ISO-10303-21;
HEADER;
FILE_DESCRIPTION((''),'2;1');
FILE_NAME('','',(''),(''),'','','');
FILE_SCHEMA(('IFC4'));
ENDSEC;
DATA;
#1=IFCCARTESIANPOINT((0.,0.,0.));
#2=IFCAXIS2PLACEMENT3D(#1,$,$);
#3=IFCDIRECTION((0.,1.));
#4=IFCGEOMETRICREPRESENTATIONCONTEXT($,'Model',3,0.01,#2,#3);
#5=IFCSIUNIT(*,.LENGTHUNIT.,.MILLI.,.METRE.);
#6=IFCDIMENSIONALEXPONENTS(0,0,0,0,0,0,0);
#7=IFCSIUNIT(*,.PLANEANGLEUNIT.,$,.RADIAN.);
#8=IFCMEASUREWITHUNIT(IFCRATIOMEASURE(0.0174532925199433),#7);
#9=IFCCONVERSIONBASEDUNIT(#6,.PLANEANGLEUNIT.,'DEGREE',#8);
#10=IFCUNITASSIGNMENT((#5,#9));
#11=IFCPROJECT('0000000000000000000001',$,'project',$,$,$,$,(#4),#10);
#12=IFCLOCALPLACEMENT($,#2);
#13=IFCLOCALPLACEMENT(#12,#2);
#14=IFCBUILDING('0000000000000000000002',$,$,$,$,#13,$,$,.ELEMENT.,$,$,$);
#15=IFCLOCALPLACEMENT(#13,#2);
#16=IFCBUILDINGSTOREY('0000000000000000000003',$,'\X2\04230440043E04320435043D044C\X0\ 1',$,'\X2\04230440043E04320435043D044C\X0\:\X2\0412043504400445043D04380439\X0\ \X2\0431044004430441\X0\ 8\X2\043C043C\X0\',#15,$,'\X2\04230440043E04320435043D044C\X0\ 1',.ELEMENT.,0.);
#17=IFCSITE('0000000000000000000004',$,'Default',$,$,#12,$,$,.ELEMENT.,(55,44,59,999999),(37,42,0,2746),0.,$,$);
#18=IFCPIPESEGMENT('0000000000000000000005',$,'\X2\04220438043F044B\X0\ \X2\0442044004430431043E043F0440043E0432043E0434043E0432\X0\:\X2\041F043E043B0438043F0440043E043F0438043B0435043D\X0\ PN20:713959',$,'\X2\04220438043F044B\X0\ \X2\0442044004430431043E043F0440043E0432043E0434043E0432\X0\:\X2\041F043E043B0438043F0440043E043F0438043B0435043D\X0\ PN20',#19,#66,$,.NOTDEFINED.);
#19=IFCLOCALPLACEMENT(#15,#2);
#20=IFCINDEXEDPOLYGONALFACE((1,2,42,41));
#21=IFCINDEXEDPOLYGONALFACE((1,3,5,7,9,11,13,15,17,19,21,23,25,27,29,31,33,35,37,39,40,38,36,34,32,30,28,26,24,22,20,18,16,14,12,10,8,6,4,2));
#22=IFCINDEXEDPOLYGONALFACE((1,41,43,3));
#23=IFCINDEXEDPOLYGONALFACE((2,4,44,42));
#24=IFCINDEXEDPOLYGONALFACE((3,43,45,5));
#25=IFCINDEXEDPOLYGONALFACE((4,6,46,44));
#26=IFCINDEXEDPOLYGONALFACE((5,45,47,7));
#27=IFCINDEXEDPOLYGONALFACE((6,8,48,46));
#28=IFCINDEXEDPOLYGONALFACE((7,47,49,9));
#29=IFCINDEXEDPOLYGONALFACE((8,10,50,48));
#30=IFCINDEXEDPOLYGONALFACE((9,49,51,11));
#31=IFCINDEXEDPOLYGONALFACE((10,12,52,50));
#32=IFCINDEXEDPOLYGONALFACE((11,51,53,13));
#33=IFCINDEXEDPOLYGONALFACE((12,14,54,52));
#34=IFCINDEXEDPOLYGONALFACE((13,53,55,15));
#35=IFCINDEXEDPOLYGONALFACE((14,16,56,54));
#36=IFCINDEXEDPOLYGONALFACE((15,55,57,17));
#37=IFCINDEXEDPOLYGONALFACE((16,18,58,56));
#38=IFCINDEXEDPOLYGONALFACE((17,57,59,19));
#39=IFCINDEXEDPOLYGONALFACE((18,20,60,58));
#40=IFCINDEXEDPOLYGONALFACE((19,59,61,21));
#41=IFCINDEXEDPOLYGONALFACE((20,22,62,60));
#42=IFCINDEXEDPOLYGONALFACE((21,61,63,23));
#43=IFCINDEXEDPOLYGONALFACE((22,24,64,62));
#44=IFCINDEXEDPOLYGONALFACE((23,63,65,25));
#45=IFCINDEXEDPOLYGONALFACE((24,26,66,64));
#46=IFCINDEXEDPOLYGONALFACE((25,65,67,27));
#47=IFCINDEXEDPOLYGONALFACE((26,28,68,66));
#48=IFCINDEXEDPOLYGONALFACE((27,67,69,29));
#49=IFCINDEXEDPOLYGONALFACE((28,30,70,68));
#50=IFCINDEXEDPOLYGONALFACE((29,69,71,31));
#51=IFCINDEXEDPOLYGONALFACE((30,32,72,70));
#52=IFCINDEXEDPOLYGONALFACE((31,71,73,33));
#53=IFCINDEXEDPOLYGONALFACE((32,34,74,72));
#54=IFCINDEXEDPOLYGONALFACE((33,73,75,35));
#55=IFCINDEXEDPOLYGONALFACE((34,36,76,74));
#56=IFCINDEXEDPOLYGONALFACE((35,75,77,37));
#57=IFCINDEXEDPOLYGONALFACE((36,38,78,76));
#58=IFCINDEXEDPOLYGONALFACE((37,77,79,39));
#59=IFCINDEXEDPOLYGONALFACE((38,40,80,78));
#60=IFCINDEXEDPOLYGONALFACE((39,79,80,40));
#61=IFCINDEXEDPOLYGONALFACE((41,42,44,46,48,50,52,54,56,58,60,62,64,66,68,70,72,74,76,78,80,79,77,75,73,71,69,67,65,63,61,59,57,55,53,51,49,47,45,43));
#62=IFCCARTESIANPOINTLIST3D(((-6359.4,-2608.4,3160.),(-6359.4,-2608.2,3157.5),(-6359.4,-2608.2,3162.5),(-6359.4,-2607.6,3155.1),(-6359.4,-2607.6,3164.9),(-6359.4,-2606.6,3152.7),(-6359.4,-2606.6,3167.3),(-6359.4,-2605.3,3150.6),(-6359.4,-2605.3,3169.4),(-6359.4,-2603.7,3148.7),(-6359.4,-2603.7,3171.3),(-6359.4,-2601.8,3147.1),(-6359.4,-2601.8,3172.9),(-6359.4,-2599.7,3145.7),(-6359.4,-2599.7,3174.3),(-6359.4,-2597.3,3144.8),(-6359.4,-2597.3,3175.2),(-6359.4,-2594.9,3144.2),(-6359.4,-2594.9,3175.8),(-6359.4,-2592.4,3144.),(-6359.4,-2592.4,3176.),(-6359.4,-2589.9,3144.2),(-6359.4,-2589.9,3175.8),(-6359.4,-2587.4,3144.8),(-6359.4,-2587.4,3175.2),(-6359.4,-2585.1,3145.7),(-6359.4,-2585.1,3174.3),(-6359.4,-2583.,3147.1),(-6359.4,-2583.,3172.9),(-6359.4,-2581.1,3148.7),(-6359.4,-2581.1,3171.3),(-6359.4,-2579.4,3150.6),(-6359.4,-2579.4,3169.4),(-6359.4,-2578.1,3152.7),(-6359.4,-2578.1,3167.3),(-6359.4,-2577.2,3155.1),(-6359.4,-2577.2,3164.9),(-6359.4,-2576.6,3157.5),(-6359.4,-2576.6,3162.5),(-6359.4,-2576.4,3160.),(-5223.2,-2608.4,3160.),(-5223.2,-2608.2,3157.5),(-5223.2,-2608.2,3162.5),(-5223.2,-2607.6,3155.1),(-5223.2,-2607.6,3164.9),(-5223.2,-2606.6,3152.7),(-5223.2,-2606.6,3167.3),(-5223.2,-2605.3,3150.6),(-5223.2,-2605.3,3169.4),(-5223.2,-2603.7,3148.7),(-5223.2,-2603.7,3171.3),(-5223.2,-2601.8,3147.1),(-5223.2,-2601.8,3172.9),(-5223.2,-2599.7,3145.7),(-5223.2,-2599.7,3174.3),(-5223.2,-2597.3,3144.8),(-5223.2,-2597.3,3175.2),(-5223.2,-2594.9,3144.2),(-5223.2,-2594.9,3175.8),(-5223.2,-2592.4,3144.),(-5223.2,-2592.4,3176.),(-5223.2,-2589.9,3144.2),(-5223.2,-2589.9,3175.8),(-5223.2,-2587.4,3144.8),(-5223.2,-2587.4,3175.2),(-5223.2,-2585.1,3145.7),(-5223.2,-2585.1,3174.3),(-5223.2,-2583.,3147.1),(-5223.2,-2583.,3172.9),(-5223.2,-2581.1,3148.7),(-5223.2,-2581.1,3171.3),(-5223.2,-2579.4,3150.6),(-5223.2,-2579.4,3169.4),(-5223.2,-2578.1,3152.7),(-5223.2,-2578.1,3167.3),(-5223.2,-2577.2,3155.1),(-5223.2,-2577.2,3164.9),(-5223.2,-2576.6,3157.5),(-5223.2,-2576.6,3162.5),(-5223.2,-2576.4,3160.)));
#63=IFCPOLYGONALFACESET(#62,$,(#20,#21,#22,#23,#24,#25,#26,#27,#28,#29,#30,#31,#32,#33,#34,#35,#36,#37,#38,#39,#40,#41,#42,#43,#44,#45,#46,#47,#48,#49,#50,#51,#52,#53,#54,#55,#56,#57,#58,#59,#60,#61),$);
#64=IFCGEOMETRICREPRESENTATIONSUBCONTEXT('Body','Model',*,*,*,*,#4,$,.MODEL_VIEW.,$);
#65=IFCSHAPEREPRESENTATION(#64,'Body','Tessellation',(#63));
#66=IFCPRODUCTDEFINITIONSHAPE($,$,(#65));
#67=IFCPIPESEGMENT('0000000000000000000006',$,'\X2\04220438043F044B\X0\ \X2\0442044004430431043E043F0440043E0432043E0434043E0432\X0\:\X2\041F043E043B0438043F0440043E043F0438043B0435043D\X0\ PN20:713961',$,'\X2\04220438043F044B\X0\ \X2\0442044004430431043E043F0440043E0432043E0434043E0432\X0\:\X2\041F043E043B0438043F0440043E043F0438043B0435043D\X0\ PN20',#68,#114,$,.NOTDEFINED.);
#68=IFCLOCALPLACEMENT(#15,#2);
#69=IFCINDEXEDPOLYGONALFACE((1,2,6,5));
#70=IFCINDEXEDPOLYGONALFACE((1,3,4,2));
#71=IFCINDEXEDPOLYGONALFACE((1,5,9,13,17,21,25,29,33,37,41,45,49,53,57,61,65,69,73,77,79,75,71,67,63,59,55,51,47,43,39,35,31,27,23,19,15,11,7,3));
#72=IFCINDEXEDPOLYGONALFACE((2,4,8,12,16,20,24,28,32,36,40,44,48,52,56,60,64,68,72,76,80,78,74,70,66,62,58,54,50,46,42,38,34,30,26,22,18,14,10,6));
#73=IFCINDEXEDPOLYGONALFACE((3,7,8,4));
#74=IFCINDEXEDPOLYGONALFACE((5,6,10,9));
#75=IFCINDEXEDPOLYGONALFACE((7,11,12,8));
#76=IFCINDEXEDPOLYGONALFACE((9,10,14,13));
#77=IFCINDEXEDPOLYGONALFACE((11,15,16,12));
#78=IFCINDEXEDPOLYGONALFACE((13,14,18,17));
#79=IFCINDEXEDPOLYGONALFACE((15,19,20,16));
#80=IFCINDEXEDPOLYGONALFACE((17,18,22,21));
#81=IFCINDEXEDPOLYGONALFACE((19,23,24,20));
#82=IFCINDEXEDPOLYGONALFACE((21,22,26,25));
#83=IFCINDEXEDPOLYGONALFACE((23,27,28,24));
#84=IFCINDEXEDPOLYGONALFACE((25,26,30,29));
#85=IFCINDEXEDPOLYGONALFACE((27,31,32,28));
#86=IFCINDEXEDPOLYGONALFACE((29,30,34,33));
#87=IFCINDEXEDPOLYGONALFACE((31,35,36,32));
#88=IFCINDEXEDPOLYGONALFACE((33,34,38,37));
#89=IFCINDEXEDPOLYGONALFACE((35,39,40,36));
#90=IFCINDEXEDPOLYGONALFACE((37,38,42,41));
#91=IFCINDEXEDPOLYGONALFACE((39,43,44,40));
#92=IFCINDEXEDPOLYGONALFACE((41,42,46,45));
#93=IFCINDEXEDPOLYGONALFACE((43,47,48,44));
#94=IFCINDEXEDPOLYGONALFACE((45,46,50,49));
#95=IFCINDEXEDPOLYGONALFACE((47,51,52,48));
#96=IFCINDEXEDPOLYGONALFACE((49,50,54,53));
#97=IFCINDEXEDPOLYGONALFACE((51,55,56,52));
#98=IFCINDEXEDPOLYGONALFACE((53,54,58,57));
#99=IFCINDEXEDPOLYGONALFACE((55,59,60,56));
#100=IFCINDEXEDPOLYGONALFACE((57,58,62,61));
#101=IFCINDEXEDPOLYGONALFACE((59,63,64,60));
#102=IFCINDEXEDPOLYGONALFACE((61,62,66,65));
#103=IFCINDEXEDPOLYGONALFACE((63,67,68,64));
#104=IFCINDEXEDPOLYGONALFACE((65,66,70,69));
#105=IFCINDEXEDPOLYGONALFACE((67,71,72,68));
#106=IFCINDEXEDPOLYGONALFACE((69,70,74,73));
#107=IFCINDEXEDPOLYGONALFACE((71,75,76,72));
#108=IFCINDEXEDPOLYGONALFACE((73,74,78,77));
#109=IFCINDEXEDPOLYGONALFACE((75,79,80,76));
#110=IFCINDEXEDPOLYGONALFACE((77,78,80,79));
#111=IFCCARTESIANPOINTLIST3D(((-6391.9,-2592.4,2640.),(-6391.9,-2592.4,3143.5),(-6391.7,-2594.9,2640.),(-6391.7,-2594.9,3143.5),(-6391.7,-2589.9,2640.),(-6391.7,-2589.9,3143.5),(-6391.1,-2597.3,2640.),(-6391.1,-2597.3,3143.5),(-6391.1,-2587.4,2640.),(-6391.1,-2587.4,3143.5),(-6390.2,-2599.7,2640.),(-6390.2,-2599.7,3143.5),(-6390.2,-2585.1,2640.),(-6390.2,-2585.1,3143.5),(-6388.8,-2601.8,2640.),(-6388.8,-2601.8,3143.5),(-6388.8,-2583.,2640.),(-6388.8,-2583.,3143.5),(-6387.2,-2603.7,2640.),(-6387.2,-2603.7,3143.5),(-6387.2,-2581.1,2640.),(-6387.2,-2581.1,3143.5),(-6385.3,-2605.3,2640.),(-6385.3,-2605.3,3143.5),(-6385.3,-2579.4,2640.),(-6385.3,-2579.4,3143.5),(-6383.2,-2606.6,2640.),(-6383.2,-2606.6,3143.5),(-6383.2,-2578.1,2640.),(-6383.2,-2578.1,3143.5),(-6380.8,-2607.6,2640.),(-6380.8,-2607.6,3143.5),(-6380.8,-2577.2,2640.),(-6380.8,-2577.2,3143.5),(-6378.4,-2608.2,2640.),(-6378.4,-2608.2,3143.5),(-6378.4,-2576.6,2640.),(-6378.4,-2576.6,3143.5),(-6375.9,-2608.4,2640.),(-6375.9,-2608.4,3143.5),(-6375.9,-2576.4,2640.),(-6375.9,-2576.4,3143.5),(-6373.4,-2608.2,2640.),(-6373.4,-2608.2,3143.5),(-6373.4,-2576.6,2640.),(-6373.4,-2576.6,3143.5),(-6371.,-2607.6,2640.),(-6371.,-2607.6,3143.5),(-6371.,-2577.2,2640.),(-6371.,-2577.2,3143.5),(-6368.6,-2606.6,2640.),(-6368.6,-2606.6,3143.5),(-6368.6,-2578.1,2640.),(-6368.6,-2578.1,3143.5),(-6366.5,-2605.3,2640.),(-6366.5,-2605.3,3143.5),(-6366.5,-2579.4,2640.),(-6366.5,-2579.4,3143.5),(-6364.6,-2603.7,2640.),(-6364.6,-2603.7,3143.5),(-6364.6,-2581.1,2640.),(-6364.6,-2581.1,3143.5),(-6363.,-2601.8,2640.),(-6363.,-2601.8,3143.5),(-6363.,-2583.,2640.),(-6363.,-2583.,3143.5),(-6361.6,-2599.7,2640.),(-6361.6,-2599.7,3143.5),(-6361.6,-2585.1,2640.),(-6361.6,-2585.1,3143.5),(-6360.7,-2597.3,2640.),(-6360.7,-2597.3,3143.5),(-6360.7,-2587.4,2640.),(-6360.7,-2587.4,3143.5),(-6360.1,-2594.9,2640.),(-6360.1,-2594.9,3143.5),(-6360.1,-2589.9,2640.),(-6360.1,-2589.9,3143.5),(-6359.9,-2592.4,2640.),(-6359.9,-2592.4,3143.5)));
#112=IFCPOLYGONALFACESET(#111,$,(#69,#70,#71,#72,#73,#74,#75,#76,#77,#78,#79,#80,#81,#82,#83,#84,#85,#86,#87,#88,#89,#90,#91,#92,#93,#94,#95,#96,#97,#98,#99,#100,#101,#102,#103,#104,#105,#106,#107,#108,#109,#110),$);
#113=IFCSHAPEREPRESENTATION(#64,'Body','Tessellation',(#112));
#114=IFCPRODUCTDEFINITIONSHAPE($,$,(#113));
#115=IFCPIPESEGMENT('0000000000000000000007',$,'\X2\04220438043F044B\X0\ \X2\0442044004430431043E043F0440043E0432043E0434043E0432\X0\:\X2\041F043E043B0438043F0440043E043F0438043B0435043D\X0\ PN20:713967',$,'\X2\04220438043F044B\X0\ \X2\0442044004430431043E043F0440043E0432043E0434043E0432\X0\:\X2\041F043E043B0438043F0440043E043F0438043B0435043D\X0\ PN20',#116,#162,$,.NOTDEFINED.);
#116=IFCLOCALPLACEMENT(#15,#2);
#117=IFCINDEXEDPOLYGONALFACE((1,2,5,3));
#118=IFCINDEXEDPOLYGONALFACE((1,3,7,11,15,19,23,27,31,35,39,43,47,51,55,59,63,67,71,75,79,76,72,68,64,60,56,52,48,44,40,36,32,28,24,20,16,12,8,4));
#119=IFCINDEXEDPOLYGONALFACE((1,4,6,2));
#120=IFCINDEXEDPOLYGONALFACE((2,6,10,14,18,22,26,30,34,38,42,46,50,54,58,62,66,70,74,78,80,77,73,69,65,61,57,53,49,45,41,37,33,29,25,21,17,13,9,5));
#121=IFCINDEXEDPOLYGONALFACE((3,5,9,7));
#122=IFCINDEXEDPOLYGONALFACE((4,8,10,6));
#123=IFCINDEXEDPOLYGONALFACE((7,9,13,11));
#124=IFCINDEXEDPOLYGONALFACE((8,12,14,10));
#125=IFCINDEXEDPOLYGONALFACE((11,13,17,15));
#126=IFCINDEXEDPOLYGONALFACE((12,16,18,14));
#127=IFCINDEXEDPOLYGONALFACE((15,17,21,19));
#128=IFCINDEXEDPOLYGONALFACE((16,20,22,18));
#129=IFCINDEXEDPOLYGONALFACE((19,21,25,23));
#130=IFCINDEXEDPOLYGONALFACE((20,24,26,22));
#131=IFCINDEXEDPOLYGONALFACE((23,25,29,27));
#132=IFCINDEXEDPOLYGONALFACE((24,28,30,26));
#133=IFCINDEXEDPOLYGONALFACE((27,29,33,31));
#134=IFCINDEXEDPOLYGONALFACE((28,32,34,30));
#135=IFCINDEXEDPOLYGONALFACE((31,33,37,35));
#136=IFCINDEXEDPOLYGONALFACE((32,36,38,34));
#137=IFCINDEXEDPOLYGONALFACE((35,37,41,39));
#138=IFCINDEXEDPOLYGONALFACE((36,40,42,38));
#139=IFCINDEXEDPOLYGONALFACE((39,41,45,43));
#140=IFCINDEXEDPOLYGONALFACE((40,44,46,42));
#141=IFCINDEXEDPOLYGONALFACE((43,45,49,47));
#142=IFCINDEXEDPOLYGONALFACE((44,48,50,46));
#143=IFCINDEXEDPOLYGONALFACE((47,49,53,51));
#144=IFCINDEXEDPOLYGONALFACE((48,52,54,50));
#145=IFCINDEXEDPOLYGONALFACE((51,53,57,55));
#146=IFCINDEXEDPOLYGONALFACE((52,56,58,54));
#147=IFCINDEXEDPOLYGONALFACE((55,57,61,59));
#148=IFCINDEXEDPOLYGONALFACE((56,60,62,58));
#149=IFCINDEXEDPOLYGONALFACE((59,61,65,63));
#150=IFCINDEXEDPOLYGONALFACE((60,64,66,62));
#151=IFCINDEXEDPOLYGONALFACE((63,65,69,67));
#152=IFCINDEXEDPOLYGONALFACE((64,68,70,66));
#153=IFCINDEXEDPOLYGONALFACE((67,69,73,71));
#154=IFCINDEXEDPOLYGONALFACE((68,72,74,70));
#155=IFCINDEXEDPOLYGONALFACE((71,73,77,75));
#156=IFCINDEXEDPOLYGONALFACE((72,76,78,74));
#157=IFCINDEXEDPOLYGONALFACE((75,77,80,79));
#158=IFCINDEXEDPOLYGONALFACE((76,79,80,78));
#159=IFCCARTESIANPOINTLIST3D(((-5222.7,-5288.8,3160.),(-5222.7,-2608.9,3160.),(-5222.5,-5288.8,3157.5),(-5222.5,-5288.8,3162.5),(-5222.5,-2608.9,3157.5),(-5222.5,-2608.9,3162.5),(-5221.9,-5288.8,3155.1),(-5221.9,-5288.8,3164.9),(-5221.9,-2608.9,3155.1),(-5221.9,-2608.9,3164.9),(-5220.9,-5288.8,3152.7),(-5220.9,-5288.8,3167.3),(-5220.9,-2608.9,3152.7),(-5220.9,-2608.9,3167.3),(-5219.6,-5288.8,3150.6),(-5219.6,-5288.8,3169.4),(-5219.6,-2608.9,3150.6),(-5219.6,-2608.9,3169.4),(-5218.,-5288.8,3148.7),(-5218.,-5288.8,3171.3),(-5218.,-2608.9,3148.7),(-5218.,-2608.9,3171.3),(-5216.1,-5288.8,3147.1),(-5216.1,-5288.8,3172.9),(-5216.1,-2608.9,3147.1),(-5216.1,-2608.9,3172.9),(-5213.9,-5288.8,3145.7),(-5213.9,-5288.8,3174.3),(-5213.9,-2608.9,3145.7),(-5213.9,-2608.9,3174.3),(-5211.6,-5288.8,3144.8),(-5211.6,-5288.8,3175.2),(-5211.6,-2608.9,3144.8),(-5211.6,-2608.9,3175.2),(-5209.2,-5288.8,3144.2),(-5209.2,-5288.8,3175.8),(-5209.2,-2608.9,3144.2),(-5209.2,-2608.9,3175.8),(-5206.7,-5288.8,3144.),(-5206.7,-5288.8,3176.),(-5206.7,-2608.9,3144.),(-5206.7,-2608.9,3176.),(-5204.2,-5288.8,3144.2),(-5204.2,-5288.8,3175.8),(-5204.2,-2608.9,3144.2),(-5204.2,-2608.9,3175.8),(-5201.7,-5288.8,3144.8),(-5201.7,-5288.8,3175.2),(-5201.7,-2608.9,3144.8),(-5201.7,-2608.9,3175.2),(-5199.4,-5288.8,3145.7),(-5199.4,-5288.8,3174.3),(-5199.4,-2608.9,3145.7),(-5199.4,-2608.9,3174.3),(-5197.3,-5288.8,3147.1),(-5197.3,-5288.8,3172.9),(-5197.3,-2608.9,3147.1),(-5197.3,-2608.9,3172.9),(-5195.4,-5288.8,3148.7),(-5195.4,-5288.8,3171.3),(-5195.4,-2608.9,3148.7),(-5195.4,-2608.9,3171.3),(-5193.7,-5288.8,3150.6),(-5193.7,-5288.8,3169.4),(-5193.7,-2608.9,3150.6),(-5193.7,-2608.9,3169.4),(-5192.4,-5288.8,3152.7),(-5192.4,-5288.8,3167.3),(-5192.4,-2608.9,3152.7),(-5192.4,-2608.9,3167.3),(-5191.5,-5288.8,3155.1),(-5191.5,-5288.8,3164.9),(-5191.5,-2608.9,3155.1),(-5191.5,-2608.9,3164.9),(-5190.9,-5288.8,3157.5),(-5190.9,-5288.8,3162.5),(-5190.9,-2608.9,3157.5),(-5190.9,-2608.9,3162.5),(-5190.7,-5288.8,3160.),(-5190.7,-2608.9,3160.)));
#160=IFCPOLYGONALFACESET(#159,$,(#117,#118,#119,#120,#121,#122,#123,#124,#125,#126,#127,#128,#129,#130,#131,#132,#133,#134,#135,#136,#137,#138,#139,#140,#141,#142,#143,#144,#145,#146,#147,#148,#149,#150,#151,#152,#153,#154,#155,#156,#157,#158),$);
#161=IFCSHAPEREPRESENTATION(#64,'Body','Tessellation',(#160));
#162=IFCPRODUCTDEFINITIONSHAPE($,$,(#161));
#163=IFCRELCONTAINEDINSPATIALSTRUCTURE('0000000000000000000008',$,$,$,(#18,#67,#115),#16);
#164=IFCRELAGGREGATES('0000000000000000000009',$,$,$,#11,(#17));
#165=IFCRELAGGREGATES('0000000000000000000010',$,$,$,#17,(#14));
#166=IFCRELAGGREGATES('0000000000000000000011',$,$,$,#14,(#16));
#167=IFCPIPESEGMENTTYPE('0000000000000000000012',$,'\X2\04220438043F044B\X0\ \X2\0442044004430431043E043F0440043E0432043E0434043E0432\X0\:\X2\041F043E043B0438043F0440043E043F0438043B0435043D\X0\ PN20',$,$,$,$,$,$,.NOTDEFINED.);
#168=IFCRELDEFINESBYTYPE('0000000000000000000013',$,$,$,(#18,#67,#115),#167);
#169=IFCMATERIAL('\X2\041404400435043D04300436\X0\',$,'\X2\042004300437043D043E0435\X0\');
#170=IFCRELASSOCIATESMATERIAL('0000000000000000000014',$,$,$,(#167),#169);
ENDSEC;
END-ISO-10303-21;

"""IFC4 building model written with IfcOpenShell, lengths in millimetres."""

from ifc_helpers import new_model, entity, si_unit, converted_unit, direction, frame, origin, place, context, subcontext, project, spatial, indexed_curve, outline, extrude, material, type_object, element, save


model = new_model("IFC4")

# Units and contexts
model_context = context("Model", 3, precision=0.01, world=origin(), true_north=direction((0.0, 1.0)))
body_context = subcontext(model_context, "Body", "Model", "MODEL_VIEW")
ifc_project = project(units=[si_unit("LENGTHUNIT", "METRE", prefix="MILLI"), converted_unit("PLANEANGLEUNIT", "DEGREE", entity("IfcRatioMeasure", 0.0174532925199433), si_unit("PLANEANGLEUNIT", "RADIAN"), dimensions=[0, 0, 0, 0, 0, 0, 0])], contexts=[model_context])

# Site, building, storey
site_placement = place(None, origin())
site = spatial("IfcSite", under=ifc_project, at=site_placement, Name="Default", CompositionType="ELEMENT", RefLatitude=(55, 44, 59, 999999), RefLongitude=(37, 42, 0, 2746), RefElevation=0.0)
building_placement = place(site_placement, origin())
building = spatial("IfcBuilding", under=site, at=building_placement, CompositionType="ELEMENT")
storey_placement = place(building_placement, origin())
storey = spatial("IfcBuildingStorey", under=building, at=storey_placement, Name="Уровень 1", ObjectType="Уровень:Верхний брус 8мм", LongName="Уровень 1", CompositionType="ELEMENT", Elevation=0.0)

# Pipe segments
ifc_material_1 = material(Name="Дренаж", Category="Разное")
pipe_segment_type_1 = type_object("IfcPipeSegmentType", Name="Типы трубопроводов:Полипропилен PN20", PredefinedType="NOTDEFINED", material=ifc_material_1)
pipe_segment_1_placement = place(storey_placement, origin())
element("IfcPipeSegment", 1, at=pipe_segment_1_placement, inside=storey, type_object=pipe_segment_type_1, Name="Типы трубопроводов:Полипропилен PN20:713959", ObjectType="Типы трубопроводов:Полипропилен PN20", PredefinedType="NOTDEFINED", context=body_context, shape_type="SweptSolid", body=[
    extrude(outline(indexed_curve([(16.0, 0.0), (15.8, 2.5), (15.2, 4.9), (14.3, 7.3), (12.9, 9.4), (11.3, 11.3), (9.4, 12.9), (7.3, 14.3), (4.9, 15.2), (2.5, 15.8), (0.0, 16.0), (-2.5, 15.8), (-4.9, 15.2), (-7.3, 14.3), (-9.4, 12.9), (-11.3, 11.3), (-12.9, 9.4), (-14.3, 7.3), (-15.2, 4.9), (-15.8, 2.5), (-16.0, 0.0), (-15.8, -2.5), (-15.2, -4.9), (-14.3, -7.3), (-12.9, -9.4), (-11.3, -11.3), (-9.4, -12.9), (-7.3, -14.3), (-4.9, -15.2), (-2.5, -15.8), (0.0, -16.0), (2.5, -15.8), (4.9, -15.2), (7.3, -14.3), (9.4, -12.9), (11.3, -11.3), (12.9, -9.4), (14.3, -7.3), (15.2, -4.9), (15.8, -2.5), (16.0, 0.0)], self_intersect=False)), frame((-6359.4, -2592.4, 3160.0), z_axis=(1.0, 0.0, 0.0), x_axis=(0.0, -1.0, 0.0)), (0.0, 0.0, 1.0), 1136.2),
])
pipe_segment_2_placement = place(storey_placement, origin())
element("IfcPipeSegment", 2, at=pipe_segment_2_placement, inside=storey, type_object=pipe_segment_type_1, Name="Типы трубопроводов:Полипропилен PN20:713961", ObjectType="Типы трубопроводов:Полипропилен PN20", PredefinedType="NOTDEFINED", context=body_context, shape_type="SweptSolid", body=[
    extrude(outline(indexed_curve([(16.0, 0.0), (15.8, 2.5), (15.2, 4.9), (14.3, 7.3), (12.9, 9.4), (11.3, 11.3), (9.4, 12.9), (7.3, 14.3), (4.9, 15.2), (2.5, 15.8), (0.0, 16.0), (-2.5, 15.8), (-4.9, 15.2), (-7.3, 14.3), (-9.4, 12.9), (-11.3, 11.3), (-12.9, 9.4), (-14.3, 7.3), (-15.2, 4.9), (-15.8, 2.5), (-16.0, 0.0), (-15.8, -2.5), (-15.2, -4.9), (-14.3, -7.3), (-12.9, -9.4), (-11.3, -11.3), (-9.4, -12.9), (-7.3, -14.3), (-4.9, -15.2), (-2.5, -15.8), (0.0, -16.0), (2.5, -15.8), (4.9, -15.2), (7.3, -14.3), (9.4, -12.9), (11.3, -11.3), (12.9, -9.4), (14.3, -7.3), (15.2, -4.9), (15.8, -2.5), (16.0, 0.0)], self_intersect=False)), frame((-6375.9, -2592.4, 2640.0), z_axis=(0.0, 0.0, 1.0), x_axis=(-1.0, 0.0, 0.0)), (0.0, 0.0, 1.0), 503.5),
])
pipe_segment_3_placement = place(storey_placement, origin())
element("IfcPipeSegment", 3, at=pipe_segment_3_placement, inside=storey, type_object=pipe_segment_type_1, Name="Типы трубопроводов:Полипропилен PN20:713967", ObjectType="Типы трубопроводов:Полипропилен PN20", PredefinedType="NOTDEFINED", context=body_context, shape_type="SweptSolid", body=[
    extrude(outline(indexed_curve([(16.0, 0.0), (15.8, 2.5), (15.2, 4.9), (14.3, 7.3), (12.9, 9.4), (11.3, 11.3), (9.4, 12.9), (7.3, 14.3), (4.9, 15.2), (2.5, 15.8), (0.0, 16.0), (-2.5, 15.8), (-4.9, 15.2), (-7.3, 14.3), (-9.4, 12.9), (-11.3, 11.3), (-12.9, 9.4), (-14.3, 7.3), (-15.2, 4.9), (-15.8, 2.5), (-16.0, 0.0), (-15.8, -2.5), (-15.2, -4.9), (-14.3, -7.3), (-12.9, -9.4), (-11.3, -11.3), (-9.4, -12.9), (-7.3, -14.3), (-4.9, -15.2), (-2.5, -15.8), (0.0, -16.0), (2.5, -15.8), (4.9, -15.2), (7.3, -14.3), (9.4, -12.9), (11.3, -11.3), (12.9, -9.4), (14.3, -7.3), (15.2, -4.9), (15.8, -2.5), (16.0, 0.0)], self_intersect=False)), frame((-5206.7, -5288.8, 3160.0), z_axis=(0.0, 1.0, 0.0), x_axis=(-1.0, 0.0, 0.0)), (0.0, 0.0, 1.0), 2679.9),
])

save(model, "model.ifc")
